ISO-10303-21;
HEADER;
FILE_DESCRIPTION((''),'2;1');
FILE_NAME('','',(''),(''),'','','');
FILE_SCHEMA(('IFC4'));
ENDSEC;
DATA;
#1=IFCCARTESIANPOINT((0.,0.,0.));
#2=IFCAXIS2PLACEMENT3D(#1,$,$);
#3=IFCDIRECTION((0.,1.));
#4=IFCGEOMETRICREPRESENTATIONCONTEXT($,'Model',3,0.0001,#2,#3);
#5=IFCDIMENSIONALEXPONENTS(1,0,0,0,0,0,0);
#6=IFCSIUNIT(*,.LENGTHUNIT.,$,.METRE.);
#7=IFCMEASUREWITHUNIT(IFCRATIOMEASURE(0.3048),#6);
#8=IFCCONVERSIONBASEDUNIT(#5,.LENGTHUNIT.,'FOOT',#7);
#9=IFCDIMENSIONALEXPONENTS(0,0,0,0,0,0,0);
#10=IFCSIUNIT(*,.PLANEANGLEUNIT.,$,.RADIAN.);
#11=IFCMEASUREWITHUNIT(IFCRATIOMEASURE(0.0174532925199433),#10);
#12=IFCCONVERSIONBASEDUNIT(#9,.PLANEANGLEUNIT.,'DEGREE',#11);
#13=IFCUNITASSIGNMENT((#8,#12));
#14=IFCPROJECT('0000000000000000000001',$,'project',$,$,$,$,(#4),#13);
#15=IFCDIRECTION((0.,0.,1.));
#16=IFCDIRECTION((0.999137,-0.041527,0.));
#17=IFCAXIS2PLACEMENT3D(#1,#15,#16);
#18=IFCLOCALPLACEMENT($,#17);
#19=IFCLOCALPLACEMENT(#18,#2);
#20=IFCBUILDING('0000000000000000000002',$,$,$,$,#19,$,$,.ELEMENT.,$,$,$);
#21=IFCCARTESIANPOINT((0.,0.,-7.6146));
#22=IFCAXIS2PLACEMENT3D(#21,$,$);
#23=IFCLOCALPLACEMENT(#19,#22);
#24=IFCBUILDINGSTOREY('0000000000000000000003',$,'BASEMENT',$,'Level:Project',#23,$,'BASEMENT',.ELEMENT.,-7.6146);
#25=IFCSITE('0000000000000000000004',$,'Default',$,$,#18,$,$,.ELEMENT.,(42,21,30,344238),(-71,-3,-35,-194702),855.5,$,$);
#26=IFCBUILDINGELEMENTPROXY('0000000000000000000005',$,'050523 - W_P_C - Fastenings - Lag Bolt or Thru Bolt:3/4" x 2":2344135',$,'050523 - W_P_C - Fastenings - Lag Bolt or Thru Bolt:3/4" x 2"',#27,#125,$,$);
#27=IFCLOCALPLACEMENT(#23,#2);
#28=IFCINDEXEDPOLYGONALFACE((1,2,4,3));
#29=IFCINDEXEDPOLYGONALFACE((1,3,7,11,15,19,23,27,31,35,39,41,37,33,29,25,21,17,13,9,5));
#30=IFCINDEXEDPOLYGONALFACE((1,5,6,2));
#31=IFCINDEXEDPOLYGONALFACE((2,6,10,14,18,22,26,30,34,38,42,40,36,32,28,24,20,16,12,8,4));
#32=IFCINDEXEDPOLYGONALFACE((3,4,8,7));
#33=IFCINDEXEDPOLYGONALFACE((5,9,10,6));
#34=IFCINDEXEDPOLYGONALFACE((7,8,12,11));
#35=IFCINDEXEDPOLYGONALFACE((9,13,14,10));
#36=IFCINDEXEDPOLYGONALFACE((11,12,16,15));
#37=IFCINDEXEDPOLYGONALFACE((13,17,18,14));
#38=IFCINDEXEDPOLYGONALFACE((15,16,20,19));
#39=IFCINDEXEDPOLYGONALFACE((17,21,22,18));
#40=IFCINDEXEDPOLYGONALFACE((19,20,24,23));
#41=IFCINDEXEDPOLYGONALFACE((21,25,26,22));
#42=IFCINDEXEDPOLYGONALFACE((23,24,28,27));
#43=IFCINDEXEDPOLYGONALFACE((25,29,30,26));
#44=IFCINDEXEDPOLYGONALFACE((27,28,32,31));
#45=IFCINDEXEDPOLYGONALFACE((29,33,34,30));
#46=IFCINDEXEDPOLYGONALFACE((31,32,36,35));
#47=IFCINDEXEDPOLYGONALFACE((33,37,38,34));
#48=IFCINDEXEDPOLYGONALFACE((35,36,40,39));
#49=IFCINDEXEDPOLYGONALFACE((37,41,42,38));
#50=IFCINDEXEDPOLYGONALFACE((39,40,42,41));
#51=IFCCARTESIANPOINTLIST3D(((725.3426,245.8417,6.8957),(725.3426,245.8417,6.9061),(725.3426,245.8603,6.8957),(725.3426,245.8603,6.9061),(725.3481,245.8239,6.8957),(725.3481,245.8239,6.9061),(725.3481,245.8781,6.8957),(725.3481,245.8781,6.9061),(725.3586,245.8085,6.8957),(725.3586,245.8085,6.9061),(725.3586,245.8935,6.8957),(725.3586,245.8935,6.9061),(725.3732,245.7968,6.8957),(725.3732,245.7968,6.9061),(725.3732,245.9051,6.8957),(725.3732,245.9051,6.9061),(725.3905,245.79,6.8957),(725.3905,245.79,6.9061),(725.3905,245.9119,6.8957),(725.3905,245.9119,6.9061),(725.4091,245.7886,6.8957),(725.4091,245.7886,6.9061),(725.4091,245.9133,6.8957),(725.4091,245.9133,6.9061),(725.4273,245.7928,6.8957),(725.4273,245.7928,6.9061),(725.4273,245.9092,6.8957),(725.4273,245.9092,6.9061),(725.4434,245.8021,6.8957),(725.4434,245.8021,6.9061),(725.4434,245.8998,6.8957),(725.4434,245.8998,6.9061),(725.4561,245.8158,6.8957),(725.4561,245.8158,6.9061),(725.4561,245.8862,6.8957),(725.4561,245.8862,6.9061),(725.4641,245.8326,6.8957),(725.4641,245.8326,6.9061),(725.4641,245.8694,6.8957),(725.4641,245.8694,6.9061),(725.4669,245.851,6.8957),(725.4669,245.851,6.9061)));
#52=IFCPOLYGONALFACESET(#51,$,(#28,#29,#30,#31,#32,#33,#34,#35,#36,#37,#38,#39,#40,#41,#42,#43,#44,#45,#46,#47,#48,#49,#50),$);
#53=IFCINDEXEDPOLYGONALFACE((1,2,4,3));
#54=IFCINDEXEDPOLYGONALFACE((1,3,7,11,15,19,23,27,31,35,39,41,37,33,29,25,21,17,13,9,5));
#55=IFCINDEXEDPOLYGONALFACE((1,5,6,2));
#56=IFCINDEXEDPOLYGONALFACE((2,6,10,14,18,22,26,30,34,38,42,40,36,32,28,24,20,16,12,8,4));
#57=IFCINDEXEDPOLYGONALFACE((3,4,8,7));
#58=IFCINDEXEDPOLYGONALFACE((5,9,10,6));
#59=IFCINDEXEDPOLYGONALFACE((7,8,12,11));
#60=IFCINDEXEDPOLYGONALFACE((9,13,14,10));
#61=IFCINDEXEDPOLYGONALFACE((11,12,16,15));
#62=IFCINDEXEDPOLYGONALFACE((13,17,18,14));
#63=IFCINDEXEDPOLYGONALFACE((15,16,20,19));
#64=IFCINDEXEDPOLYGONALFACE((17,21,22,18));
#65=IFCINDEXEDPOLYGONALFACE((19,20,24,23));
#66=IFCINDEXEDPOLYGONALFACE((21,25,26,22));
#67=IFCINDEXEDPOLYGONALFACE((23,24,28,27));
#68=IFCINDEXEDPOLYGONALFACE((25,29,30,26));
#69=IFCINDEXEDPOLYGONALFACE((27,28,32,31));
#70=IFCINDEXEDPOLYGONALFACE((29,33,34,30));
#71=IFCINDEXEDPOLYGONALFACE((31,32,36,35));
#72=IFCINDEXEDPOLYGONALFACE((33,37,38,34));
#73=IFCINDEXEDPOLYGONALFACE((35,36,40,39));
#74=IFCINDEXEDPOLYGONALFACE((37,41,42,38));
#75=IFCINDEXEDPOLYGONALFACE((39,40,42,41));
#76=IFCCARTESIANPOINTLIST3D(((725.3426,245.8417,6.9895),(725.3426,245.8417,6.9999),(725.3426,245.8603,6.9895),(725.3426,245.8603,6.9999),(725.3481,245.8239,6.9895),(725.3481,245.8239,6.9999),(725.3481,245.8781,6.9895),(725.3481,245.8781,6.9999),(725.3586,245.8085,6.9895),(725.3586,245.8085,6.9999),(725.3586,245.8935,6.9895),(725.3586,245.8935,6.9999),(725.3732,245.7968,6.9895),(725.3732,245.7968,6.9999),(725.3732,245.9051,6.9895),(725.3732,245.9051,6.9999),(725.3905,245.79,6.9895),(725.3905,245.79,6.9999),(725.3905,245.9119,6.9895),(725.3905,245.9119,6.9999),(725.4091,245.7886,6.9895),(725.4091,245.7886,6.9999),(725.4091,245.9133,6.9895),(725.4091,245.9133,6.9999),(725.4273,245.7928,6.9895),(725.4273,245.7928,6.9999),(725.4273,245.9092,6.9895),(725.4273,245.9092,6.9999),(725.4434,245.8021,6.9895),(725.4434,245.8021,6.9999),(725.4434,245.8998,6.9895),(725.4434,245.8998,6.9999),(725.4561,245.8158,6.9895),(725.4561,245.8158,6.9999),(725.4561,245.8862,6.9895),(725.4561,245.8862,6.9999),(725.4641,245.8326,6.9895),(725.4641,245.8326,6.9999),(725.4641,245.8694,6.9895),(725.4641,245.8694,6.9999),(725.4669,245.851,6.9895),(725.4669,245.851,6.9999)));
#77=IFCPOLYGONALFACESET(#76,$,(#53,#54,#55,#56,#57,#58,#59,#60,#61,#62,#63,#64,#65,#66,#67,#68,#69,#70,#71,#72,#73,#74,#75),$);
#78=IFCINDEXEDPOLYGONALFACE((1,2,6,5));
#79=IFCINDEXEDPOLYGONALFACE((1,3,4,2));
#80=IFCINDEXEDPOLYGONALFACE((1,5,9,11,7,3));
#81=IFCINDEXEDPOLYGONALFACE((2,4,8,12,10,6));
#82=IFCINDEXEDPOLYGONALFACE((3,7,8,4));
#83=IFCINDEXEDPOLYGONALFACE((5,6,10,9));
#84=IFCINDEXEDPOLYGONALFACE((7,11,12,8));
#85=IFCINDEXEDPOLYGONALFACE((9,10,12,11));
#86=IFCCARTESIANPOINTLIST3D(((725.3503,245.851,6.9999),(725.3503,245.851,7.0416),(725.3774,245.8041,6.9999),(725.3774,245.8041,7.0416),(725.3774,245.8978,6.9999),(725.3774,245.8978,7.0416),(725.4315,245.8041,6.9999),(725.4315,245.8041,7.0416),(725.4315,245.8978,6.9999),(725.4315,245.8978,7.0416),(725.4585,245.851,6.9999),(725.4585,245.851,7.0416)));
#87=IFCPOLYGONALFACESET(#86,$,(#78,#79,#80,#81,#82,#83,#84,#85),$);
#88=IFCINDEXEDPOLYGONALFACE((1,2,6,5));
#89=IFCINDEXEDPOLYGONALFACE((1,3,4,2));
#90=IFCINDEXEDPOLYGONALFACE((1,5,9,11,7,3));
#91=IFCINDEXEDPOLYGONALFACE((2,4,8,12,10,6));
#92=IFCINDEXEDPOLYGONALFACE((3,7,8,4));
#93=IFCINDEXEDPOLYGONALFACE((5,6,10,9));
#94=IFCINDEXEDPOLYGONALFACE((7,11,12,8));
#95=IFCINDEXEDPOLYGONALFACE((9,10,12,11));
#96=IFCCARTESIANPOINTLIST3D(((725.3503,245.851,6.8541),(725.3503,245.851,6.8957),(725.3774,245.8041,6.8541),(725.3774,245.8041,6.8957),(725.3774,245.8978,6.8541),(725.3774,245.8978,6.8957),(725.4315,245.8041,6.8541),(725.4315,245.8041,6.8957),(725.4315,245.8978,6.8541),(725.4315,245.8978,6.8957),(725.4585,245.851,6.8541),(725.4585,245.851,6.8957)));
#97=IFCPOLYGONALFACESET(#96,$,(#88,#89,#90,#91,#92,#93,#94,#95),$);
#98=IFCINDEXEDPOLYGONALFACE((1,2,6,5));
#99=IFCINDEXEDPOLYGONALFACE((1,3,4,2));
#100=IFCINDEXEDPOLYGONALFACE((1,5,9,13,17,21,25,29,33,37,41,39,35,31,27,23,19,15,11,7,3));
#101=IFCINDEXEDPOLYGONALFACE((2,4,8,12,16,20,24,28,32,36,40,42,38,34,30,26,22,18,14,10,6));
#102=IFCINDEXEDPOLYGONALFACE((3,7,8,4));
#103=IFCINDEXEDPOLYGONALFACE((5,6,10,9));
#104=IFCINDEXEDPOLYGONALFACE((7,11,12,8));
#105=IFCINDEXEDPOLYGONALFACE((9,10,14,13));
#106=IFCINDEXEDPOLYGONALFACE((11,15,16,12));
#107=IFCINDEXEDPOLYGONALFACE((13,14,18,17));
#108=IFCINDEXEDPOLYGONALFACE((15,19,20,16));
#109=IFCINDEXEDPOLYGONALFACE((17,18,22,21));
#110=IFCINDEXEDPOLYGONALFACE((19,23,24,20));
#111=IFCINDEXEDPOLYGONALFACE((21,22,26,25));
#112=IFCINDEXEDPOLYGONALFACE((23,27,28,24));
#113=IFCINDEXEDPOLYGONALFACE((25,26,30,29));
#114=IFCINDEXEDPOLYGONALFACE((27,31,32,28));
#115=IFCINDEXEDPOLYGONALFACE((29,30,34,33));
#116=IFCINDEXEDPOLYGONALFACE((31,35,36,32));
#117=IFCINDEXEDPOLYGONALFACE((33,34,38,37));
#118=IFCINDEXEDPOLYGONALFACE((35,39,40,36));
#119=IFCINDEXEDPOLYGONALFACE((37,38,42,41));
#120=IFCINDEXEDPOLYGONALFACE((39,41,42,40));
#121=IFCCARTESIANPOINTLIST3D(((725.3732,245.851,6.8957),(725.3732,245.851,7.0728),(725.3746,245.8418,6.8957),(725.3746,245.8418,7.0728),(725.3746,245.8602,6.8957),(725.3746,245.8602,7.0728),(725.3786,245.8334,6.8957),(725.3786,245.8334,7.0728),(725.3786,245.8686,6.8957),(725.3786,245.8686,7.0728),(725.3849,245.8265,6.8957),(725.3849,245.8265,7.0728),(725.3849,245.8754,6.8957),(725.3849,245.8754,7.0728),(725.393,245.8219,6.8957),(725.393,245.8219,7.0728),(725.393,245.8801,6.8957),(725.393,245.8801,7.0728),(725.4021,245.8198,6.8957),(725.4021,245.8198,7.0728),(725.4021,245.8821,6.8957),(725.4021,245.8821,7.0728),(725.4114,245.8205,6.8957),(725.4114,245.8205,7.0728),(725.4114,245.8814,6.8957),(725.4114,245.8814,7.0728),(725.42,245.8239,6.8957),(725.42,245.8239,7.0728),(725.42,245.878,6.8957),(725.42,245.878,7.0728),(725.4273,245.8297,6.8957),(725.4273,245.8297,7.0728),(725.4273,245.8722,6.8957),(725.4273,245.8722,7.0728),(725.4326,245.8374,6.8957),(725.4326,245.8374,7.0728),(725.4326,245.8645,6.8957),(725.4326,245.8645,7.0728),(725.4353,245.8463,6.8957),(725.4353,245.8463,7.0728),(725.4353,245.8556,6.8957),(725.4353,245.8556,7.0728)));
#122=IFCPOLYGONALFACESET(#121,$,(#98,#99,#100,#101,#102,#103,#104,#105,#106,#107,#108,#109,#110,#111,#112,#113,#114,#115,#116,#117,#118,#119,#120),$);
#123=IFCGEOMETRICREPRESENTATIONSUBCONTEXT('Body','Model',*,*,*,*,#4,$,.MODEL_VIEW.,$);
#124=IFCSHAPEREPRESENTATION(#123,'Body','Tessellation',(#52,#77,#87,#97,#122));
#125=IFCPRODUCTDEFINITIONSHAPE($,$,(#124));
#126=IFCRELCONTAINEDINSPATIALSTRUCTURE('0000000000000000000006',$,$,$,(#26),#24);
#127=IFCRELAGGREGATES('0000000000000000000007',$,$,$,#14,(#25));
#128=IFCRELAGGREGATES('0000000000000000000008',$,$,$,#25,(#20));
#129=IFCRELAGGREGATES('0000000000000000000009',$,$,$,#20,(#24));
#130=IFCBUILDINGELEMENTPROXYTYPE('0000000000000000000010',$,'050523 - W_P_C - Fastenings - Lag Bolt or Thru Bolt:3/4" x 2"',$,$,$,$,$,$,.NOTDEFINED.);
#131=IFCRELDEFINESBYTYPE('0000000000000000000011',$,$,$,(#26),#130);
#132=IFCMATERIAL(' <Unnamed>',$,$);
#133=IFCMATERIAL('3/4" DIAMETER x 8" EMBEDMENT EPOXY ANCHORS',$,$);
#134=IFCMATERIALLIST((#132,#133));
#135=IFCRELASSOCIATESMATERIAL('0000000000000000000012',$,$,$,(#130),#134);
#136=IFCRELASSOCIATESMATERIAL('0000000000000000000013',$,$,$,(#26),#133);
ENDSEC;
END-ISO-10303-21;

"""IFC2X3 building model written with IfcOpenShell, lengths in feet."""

from ifc_helpers import new_model, entity, si_unit, converted_unit, direction, frame, frame_2d, origin, place, context, subcontext, project, spatial, polyline, circle, outline, extrude, source, transform, mapped, material, material_list, type_object, type_shapes, element, save


model = new_model("IFC2X3")

# Units and contexts
model_context = context("Model", 3, precision=0.0001, world=origin(), true_north=direction((0.0, 1.0)))
body_context = subcontext(model_context, "Body", "Model", "MODEL_VIEW")
ifc_project = project(units=[converted_unit("LENGTHUNIT", "FOOT", entity("IfcRatioMeasure", 0.3048), si_unit("LENGTHUNIT", "METRE"), dimensions=[1, 0, 0, 0, 0, 0, 0]), converted_unit("PLANEANGLEUNIT", "DEGREE", entity("IfcRatioMeasure", 0.0174532925199433), si_unit("PLANEANGLEUNIT", "RADIAN"), dimensions=[0, 0, 0, 0, 0, 0, 0])], contexts=[model_context])

# Site, building, storey
site_placement = place(None, frame((0.0, 0.0, 0.0), z_axis=(0.0, 0.0, 1.0), x_axis=(0.999137, -0.041527, 0.0)))
site = spatial("IfcSite", under=ifc_project, at=site_placement, Name="Default", CompositionType="ELEMENT", RefLatitude=(42, 21, 30, 344238), RefLongitude=(-71, -3, -35, -194702), RefElevation=855.5)
building_placement = place(site_placement, origin())
building = spatial("IfcBuilding", under=site, at=building_placement, CompositionType="ELEMENT")
storey_placement = place(building_placement, frame((0.0, 0.0, -7.6146)))
storey = spatial("IfcBuildingStorey", under=building, at=storey_placement, Name="BASEMENT", ObjectType="Level:Project", LongName="BASEMENT", CompositionType="ELEMENT", Elevation=-7.6146)

# Building element proxy
ifc_material_1 = material(Name=" <Unnamed>")
ifc_material_2 = material(Name="3/4\" DIAMETER x 8\" EMBEDMENT EPOXY ANCHORS")
ifc_material_list_1 = material_list([ifc_material_1, ifc_material_2])
building_element_proxy_type_1 = type_object("IfcBuildingElementProxyType", Name="050523 - W_P_C - Fastenings - Lag Bolt or Thru Bolt:3/4\" x 2\"", PredefinedType="NOTDEFINED", material=ifc_material_list_1)
shared_shape_1 = source(origin(), body_context, "Body", "SweptSolid", [
    extrude(circle(Radius=0.0625, at=frame_2d((0.0, 0.0), x_axis=(1.0, 0.0))), frame((0.0, 0.0, 0.0), z_axis=(0.0, 0.0, 1.0), x_axis=(0.0, -1.0, 0.0)), (0.0, 0.0, 1.0), 0.0104),
    extrude(circle(Radius=0.0625, at=frame_2d((0.0, 0.0), x_axis=(1.0, 0.0))), frame((0.0, 0.0, -0.0938), z_axis=(0.0, 0.0, 1.0), x_axis=(0.0, -1.0, 0.0)), (0.0, 0.0, 1.0), 0.0104),
    extrude(outline(polyline([(-0.0271, -0.0469), (0.0271, -0.0469), (0.0541, 0.0), (0.0271, 0.0469), (-0.0271, 0.0469), (-0.0541, 0.0), (-0.0271, -0.0469)])), frame((0.0, 0.0, -0.1354), z_axis=(0.0, 0.0, 1.0), x_axis=(0.866025, -0.5, 0.0)), (0.0, 0.0, 1.0), 0.0417),
    extrude(outline(polyline([(-0.0271, -0.0469), (0.0271, -0.0469), (0.0541, 0.0), (0.0271, 0.0469), (-0.0271, 0.0469), (-0.0541, 0.0), (-0.0271, -0.0469)])), frame((0.0, 0.0, 0.0104), z_axis=(0.0, 0.0, 1.0), x_axis=(0.0, -1.0, 0.0)), (0.0, 0.0, 1.0), 0.0417),
    extrude(circle(Radius=0.0312, at=frame_2d((0.0, 0.0), x_axis=(1.0, 0.0))), frame((0.0, 0.0, -0.1667), z_axis=(0.0, 0.0, 1.0), x_axis=(0.0, 1.0, 0.0)), (0.0, 0.0, 1.0), 0.1771),
])
type_shapes(building_element_proxy_type_1, [shared_shape_1])
for number, where, z_axis, x_axis, name in (
    (1, (725.4044, 245.851, 6.9061), (0.0, 0.0, -1.0), (0.0, -1.0, 0.0), "050523 - W_P_C - Fastenings - Lag Bolt or Thru Bolt:3/4\" x 2\":2344135"),
):
    element("IfcBuildingElementProxy", number, at=place(storey_placement, frame(where, z_axis=z_axis, x_axis=x_axis)), inside=storey, type_object=building_element_proxy_type_1, material=ifc_material_2, Name=name, ObjectType="050523 - W_P_C - Fastenings - Lag Bolt or Thru Bolt:3/4\" x 2\"", context=body_context, shape_type="MappedRepresentation", body=[
        mapped(shared_shape_1, transform((0.0, 0.0, 0.0), scale=1.0)),
    ])

save(model, "model.ifc")
